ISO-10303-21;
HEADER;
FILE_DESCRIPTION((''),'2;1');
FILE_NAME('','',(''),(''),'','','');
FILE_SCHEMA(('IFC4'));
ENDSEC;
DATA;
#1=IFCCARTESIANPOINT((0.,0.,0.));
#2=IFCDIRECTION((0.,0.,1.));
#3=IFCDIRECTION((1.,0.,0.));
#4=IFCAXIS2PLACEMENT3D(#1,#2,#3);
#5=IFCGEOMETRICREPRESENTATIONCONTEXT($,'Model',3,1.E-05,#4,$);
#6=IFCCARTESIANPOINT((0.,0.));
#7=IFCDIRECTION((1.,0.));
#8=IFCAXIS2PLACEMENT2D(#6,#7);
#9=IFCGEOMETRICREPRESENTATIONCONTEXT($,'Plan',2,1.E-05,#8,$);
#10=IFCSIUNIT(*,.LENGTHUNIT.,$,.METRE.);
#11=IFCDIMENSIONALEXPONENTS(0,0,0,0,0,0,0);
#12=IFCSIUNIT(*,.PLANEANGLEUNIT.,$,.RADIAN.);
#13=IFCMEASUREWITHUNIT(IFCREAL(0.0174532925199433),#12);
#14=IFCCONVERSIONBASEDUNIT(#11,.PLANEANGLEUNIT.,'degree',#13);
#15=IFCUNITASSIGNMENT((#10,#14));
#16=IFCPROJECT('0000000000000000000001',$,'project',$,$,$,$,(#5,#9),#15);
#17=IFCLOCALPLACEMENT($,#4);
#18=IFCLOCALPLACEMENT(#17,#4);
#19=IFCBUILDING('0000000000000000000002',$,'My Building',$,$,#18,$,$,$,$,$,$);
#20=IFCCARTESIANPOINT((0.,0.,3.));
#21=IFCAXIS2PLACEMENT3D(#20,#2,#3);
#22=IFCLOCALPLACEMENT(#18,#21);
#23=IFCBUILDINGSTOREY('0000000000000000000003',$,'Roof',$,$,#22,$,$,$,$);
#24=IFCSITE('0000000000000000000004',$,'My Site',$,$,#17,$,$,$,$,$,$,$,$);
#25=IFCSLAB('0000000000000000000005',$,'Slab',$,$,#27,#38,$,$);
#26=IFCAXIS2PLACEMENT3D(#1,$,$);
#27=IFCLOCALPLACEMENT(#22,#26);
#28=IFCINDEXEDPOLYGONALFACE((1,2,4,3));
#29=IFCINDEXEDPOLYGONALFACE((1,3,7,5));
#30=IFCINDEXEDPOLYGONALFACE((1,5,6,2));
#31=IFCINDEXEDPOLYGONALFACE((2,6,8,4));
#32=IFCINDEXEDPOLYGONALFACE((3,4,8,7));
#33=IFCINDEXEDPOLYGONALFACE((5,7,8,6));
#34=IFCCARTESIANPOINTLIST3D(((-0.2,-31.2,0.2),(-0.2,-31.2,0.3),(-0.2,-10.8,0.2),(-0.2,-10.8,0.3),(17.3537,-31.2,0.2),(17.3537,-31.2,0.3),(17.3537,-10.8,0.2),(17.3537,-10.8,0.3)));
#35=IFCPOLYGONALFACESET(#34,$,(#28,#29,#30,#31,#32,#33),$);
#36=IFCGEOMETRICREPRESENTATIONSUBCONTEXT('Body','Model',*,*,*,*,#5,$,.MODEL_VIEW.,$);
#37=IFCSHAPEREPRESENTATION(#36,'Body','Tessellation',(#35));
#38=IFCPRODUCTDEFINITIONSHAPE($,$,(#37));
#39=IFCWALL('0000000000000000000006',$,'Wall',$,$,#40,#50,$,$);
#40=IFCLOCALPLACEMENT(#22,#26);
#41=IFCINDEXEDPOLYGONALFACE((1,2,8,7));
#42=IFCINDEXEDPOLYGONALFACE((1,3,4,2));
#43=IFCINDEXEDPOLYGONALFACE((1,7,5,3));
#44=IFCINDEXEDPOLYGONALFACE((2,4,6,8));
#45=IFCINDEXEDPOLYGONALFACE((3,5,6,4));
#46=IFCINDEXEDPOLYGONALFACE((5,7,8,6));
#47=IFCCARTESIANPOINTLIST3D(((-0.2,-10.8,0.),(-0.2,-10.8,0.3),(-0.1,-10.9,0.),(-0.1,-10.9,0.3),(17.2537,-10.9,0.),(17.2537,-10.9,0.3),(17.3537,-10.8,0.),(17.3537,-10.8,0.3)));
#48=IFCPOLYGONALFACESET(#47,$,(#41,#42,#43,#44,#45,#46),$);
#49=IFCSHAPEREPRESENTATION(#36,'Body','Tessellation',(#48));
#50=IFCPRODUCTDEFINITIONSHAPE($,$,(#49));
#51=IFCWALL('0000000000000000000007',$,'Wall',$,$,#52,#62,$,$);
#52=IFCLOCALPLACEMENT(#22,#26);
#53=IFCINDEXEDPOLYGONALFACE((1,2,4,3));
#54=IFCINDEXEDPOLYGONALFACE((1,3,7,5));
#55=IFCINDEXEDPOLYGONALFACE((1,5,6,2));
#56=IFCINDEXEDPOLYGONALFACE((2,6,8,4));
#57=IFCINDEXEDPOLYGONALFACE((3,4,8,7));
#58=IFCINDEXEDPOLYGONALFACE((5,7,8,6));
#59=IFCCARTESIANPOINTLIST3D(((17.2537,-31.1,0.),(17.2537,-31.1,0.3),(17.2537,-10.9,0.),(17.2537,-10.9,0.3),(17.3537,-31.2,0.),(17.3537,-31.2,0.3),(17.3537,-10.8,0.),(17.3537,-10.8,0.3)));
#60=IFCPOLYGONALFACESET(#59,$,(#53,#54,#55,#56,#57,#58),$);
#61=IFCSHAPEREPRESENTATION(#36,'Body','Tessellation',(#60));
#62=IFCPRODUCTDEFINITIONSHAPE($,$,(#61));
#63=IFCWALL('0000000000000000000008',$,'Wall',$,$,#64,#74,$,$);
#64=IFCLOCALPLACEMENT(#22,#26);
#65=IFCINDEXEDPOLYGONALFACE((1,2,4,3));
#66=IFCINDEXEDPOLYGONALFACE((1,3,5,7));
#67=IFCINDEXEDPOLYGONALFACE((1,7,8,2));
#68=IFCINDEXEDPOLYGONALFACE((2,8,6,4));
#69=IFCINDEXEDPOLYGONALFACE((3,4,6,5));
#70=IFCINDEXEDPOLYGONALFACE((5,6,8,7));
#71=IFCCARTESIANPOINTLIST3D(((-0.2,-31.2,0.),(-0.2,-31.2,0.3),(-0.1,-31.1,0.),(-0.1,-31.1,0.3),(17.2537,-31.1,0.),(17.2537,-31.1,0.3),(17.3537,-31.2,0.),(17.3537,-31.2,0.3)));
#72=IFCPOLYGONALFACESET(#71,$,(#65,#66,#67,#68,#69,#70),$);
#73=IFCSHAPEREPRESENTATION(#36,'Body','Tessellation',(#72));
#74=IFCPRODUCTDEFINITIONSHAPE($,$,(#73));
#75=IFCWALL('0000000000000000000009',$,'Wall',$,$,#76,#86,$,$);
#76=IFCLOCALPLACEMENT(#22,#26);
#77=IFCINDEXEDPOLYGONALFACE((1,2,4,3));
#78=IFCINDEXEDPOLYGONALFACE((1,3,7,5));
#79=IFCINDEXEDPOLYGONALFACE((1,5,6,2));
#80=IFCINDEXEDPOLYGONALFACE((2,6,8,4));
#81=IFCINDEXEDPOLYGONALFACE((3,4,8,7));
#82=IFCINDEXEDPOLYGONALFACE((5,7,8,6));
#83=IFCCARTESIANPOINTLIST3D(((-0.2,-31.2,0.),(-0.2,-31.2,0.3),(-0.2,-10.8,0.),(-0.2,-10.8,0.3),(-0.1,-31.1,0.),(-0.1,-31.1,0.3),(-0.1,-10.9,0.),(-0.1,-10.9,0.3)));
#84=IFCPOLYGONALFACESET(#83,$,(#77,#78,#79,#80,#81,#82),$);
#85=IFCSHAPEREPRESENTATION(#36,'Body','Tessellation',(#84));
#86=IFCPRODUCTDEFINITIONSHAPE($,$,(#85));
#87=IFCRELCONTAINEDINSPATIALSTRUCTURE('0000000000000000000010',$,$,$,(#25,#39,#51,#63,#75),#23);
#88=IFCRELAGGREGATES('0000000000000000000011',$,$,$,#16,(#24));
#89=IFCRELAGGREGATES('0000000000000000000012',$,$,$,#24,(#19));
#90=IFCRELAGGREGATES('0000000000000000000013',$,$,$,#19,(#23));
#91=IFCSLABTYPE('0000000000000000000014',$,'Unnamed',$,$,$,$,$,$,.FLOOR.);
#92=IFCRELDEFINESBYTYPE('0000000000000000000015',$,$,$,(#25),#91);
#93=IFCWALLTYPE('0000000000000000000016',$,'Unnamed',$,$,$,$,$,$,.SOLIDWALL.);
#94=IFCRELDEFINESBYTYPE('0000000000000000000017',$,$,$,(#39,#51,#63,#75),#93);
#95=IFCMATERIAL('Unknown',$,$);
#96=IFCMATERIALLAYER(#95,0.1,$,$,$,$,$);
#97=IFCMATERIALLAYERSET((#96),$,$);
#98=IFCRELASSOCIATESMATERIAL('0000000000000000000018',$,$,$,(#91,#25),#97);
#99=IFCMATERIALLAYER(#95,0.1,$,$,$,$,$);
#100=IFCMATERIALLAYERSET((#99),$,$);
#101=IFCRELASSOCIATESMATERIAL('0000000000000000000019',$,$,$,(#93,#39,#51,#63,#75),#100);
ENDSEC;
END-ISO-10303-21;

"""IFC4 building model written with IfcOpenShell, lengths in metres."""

from ifc_helpers import new_model, entity, si_unit, converted_unit, frame, origin_with_axes, origin_2d_with_axis, place, context, subcontext, project, spatial, line, indexed_curve, outline, extrude, material, layer, layer_set, layer_usage, type_object, element, save


model = new_model("IFC4")

# Units and contexts
model_context = context("Model", 3, precision=1e-05, world=origin_with_axes())
plan_context = context("Plan", 2, precision=1e-05, world=origin_2d_with_axis())
body_context = subcontext(model_context, "Body", "Model", "MODEL_VIEW")
ifc_project = project(units=[si_unit("LENGTHUNIT", "METRE"), converted_unit("PLANEANGLEUNIT", "degree", entity("IfcReal", 0.0174532925199433), si_unit("PLANEANGLEUNIT", "RADIAN"), dimensions=[0, 0, 0, 0, 0, 0, 0])], contexts=[model_context, plan_context])

# Site, building, storey
site_placement = place(None, origin_with_axes())
site = spatial("IfcSite", under=ifc_project, at=site_placement, Name="My Site")
building_placement = place(site_placement, origin_with_axes())
building = spatial("IfcBuilding", under=site, at=building_placement, Name="My Building")
storey_placement = place(building_placement, frame((0.0, 0.0, 3.0), z_axis=(0.0, 0.0, 1.0), x_axis=(1.0, 0.0, 0.0)))
storey = spatial("IfcBuildingStorey", under=building, at=storey_placement, Name="Roof")

# Slab
ifc_material = material(Name="Unknown")
ifc_layer_1 = layer(ifc_material, 0.1)
ifc_layer_set_1 = layer_set([ifc_layer_1])
ifc_layer_usage_1 = layer_usage(ifc_layer_set_1, "AXIS3", "POSITIVE", -0.1)
slab_type = type_object("IfcSlabType", Name="Unnamed", PredefinedType="FLOOR", material=ifc_layer_set_1)
slab_placement = place(storey_placement, frame((-0.2, -10.8, 0.3), z_axis=(0.0, 0.0, 1.0), x_axis=(1.0, 0.0, 0.0)))
element("IfcSlab", 1, at=slab_placement, inside=storey, type_object=slab_type, material=ifc_layer_usage_1, Name="Slab", context=body_context, shape_type="SweptSolid", body=[
    extrude(outline(indexed_curve([(0.0, 0.0), (17.5537, 0.0), (17.5537, -20.4), (0.0, -20.4), (0.0, 0.0)])), frame((0.0, 0.0, -0.1), z_axis=(0.0, 0.0, 1.0), x_axis=(1.0, 0.0, 0.0)), (0.0, 0.0, 1.0), 0.1),
])

# Walls
ifc_layer_2 = layer(ifc_material, 0.1)
ifc_layer_set_2 = layer_set([ifc_layer_2])
ifc_layer_usage_2 = layer_usage(ifc_layer_set_2, "AXIS2", "POSITIVE", 0.0)
wall_type = type_object("IfcWallType", Name="Unnamed", PredefinedType="SOLIDWALL", material=ifc_layer_set_2)
wall_1_placement = place(storey_placement, frame((-0.1, -10.9, 0.0), z_axis=(0.0, 0.0, 1.0), x_axis=(1.0, 0.0, 0.0)))
element("IfcWall", 2, at=wall_1_placement, inside=storey, type_object=wall_type, material=ifc_layer_usage_2, Name="Wall", context=body_context, shape_type="SweptSolid", body=[
    extrude(outline(indexed_curve([(0.0, 0.0), (-0.1, 0.1), (17.4537, 0.1), (17.3537, 0.0)], segments=[line(1, 2, 3, 4, 1)])), origin_with_axes(), (0.0, 0.0, 1.0), 0.3),
])
ifc_layer_usage_3 = layer_usage(ifc_layer_set_2, "AXIS2", "POSITIVE", 0.0)
wall_2_placement = place(storey_placement, frame((17.2537, -10.9, 0.0), z_axis=(0.0, 0.0, 1.0), x_axis=(0.0, -1.0, 0.0)))
element("IfcWall", 3, at=wall_2_placement, inside=storey, type_object=wall_type, material=ifc_layer_usage_3, Name="Wall", context=body_context, shape_type="SweptSolid", body=[
    extrude(outline(indexed_curve([(0.0, 0.0), (-0.1, 0.1), (20.3, 0.1), (20.2, 0.0)], segments=[line(1, 2, 3, 4, 1)])), origin_with_axes(), (0.0, 0.0, 1.0), 0.3),
])
ifc_layer_usage_4 = layer_usage(ifc_layer_set_2, "AXIS2", "POSITIVE", 0.0)
wall_3_placement = place(storey_placement, frame((17.2537, -31.1, 0.0), z_axis=(0.0, 0.0, 1.0), x_axis=(-1.0, 0.0, 0.0)))
element("IfcWall", 4, at=wall_3_placement, inside=storey, type_object=wall_type, material=ifc_layer_usage_4, Name="Wall", context=body_context, shape_type="SweptSolid", body=[
    extrude(outline(indexed_curve([(0.0, 0.0), (-0.1, 0.1), (17.4537, 0.1), (17.3537, 0.0)], segments=[line(1, 2, 3, 4, 1)])), origin_with_axes(), (0.0, 0.0, 1.0), 0.3),
])
ifc_layer_usage_5 = layer_usage(ifc_layer_set_2, "AXIS2", "POSITIVE", 0.0)
wall_4_placement = place(storey_placement, frame((-0.1, -31.1, 0.0), z_axis=(0.0, 0.0, 1.0), x_axis=(0.0, 1.0, 0.0)))
element("IfcWall", 5, at=wall_4_placement, inside=storey, type_object=wall_type, material=ifc_layer_usage_5, Name="Wall", context=body_context, shape_type="SweptSolid", body=[
    extrude(outline(indexed_curve([(0.0, 0.0), (-0.1, 0.1), (20.3, 0.1), (20.2, 0.0)], segments=[line(1, 2, 3, 4, 1)])), origin_with_axes(), (0.0, 0.0, 1.0), 0.3),
])

save(model, "model.ifc")
